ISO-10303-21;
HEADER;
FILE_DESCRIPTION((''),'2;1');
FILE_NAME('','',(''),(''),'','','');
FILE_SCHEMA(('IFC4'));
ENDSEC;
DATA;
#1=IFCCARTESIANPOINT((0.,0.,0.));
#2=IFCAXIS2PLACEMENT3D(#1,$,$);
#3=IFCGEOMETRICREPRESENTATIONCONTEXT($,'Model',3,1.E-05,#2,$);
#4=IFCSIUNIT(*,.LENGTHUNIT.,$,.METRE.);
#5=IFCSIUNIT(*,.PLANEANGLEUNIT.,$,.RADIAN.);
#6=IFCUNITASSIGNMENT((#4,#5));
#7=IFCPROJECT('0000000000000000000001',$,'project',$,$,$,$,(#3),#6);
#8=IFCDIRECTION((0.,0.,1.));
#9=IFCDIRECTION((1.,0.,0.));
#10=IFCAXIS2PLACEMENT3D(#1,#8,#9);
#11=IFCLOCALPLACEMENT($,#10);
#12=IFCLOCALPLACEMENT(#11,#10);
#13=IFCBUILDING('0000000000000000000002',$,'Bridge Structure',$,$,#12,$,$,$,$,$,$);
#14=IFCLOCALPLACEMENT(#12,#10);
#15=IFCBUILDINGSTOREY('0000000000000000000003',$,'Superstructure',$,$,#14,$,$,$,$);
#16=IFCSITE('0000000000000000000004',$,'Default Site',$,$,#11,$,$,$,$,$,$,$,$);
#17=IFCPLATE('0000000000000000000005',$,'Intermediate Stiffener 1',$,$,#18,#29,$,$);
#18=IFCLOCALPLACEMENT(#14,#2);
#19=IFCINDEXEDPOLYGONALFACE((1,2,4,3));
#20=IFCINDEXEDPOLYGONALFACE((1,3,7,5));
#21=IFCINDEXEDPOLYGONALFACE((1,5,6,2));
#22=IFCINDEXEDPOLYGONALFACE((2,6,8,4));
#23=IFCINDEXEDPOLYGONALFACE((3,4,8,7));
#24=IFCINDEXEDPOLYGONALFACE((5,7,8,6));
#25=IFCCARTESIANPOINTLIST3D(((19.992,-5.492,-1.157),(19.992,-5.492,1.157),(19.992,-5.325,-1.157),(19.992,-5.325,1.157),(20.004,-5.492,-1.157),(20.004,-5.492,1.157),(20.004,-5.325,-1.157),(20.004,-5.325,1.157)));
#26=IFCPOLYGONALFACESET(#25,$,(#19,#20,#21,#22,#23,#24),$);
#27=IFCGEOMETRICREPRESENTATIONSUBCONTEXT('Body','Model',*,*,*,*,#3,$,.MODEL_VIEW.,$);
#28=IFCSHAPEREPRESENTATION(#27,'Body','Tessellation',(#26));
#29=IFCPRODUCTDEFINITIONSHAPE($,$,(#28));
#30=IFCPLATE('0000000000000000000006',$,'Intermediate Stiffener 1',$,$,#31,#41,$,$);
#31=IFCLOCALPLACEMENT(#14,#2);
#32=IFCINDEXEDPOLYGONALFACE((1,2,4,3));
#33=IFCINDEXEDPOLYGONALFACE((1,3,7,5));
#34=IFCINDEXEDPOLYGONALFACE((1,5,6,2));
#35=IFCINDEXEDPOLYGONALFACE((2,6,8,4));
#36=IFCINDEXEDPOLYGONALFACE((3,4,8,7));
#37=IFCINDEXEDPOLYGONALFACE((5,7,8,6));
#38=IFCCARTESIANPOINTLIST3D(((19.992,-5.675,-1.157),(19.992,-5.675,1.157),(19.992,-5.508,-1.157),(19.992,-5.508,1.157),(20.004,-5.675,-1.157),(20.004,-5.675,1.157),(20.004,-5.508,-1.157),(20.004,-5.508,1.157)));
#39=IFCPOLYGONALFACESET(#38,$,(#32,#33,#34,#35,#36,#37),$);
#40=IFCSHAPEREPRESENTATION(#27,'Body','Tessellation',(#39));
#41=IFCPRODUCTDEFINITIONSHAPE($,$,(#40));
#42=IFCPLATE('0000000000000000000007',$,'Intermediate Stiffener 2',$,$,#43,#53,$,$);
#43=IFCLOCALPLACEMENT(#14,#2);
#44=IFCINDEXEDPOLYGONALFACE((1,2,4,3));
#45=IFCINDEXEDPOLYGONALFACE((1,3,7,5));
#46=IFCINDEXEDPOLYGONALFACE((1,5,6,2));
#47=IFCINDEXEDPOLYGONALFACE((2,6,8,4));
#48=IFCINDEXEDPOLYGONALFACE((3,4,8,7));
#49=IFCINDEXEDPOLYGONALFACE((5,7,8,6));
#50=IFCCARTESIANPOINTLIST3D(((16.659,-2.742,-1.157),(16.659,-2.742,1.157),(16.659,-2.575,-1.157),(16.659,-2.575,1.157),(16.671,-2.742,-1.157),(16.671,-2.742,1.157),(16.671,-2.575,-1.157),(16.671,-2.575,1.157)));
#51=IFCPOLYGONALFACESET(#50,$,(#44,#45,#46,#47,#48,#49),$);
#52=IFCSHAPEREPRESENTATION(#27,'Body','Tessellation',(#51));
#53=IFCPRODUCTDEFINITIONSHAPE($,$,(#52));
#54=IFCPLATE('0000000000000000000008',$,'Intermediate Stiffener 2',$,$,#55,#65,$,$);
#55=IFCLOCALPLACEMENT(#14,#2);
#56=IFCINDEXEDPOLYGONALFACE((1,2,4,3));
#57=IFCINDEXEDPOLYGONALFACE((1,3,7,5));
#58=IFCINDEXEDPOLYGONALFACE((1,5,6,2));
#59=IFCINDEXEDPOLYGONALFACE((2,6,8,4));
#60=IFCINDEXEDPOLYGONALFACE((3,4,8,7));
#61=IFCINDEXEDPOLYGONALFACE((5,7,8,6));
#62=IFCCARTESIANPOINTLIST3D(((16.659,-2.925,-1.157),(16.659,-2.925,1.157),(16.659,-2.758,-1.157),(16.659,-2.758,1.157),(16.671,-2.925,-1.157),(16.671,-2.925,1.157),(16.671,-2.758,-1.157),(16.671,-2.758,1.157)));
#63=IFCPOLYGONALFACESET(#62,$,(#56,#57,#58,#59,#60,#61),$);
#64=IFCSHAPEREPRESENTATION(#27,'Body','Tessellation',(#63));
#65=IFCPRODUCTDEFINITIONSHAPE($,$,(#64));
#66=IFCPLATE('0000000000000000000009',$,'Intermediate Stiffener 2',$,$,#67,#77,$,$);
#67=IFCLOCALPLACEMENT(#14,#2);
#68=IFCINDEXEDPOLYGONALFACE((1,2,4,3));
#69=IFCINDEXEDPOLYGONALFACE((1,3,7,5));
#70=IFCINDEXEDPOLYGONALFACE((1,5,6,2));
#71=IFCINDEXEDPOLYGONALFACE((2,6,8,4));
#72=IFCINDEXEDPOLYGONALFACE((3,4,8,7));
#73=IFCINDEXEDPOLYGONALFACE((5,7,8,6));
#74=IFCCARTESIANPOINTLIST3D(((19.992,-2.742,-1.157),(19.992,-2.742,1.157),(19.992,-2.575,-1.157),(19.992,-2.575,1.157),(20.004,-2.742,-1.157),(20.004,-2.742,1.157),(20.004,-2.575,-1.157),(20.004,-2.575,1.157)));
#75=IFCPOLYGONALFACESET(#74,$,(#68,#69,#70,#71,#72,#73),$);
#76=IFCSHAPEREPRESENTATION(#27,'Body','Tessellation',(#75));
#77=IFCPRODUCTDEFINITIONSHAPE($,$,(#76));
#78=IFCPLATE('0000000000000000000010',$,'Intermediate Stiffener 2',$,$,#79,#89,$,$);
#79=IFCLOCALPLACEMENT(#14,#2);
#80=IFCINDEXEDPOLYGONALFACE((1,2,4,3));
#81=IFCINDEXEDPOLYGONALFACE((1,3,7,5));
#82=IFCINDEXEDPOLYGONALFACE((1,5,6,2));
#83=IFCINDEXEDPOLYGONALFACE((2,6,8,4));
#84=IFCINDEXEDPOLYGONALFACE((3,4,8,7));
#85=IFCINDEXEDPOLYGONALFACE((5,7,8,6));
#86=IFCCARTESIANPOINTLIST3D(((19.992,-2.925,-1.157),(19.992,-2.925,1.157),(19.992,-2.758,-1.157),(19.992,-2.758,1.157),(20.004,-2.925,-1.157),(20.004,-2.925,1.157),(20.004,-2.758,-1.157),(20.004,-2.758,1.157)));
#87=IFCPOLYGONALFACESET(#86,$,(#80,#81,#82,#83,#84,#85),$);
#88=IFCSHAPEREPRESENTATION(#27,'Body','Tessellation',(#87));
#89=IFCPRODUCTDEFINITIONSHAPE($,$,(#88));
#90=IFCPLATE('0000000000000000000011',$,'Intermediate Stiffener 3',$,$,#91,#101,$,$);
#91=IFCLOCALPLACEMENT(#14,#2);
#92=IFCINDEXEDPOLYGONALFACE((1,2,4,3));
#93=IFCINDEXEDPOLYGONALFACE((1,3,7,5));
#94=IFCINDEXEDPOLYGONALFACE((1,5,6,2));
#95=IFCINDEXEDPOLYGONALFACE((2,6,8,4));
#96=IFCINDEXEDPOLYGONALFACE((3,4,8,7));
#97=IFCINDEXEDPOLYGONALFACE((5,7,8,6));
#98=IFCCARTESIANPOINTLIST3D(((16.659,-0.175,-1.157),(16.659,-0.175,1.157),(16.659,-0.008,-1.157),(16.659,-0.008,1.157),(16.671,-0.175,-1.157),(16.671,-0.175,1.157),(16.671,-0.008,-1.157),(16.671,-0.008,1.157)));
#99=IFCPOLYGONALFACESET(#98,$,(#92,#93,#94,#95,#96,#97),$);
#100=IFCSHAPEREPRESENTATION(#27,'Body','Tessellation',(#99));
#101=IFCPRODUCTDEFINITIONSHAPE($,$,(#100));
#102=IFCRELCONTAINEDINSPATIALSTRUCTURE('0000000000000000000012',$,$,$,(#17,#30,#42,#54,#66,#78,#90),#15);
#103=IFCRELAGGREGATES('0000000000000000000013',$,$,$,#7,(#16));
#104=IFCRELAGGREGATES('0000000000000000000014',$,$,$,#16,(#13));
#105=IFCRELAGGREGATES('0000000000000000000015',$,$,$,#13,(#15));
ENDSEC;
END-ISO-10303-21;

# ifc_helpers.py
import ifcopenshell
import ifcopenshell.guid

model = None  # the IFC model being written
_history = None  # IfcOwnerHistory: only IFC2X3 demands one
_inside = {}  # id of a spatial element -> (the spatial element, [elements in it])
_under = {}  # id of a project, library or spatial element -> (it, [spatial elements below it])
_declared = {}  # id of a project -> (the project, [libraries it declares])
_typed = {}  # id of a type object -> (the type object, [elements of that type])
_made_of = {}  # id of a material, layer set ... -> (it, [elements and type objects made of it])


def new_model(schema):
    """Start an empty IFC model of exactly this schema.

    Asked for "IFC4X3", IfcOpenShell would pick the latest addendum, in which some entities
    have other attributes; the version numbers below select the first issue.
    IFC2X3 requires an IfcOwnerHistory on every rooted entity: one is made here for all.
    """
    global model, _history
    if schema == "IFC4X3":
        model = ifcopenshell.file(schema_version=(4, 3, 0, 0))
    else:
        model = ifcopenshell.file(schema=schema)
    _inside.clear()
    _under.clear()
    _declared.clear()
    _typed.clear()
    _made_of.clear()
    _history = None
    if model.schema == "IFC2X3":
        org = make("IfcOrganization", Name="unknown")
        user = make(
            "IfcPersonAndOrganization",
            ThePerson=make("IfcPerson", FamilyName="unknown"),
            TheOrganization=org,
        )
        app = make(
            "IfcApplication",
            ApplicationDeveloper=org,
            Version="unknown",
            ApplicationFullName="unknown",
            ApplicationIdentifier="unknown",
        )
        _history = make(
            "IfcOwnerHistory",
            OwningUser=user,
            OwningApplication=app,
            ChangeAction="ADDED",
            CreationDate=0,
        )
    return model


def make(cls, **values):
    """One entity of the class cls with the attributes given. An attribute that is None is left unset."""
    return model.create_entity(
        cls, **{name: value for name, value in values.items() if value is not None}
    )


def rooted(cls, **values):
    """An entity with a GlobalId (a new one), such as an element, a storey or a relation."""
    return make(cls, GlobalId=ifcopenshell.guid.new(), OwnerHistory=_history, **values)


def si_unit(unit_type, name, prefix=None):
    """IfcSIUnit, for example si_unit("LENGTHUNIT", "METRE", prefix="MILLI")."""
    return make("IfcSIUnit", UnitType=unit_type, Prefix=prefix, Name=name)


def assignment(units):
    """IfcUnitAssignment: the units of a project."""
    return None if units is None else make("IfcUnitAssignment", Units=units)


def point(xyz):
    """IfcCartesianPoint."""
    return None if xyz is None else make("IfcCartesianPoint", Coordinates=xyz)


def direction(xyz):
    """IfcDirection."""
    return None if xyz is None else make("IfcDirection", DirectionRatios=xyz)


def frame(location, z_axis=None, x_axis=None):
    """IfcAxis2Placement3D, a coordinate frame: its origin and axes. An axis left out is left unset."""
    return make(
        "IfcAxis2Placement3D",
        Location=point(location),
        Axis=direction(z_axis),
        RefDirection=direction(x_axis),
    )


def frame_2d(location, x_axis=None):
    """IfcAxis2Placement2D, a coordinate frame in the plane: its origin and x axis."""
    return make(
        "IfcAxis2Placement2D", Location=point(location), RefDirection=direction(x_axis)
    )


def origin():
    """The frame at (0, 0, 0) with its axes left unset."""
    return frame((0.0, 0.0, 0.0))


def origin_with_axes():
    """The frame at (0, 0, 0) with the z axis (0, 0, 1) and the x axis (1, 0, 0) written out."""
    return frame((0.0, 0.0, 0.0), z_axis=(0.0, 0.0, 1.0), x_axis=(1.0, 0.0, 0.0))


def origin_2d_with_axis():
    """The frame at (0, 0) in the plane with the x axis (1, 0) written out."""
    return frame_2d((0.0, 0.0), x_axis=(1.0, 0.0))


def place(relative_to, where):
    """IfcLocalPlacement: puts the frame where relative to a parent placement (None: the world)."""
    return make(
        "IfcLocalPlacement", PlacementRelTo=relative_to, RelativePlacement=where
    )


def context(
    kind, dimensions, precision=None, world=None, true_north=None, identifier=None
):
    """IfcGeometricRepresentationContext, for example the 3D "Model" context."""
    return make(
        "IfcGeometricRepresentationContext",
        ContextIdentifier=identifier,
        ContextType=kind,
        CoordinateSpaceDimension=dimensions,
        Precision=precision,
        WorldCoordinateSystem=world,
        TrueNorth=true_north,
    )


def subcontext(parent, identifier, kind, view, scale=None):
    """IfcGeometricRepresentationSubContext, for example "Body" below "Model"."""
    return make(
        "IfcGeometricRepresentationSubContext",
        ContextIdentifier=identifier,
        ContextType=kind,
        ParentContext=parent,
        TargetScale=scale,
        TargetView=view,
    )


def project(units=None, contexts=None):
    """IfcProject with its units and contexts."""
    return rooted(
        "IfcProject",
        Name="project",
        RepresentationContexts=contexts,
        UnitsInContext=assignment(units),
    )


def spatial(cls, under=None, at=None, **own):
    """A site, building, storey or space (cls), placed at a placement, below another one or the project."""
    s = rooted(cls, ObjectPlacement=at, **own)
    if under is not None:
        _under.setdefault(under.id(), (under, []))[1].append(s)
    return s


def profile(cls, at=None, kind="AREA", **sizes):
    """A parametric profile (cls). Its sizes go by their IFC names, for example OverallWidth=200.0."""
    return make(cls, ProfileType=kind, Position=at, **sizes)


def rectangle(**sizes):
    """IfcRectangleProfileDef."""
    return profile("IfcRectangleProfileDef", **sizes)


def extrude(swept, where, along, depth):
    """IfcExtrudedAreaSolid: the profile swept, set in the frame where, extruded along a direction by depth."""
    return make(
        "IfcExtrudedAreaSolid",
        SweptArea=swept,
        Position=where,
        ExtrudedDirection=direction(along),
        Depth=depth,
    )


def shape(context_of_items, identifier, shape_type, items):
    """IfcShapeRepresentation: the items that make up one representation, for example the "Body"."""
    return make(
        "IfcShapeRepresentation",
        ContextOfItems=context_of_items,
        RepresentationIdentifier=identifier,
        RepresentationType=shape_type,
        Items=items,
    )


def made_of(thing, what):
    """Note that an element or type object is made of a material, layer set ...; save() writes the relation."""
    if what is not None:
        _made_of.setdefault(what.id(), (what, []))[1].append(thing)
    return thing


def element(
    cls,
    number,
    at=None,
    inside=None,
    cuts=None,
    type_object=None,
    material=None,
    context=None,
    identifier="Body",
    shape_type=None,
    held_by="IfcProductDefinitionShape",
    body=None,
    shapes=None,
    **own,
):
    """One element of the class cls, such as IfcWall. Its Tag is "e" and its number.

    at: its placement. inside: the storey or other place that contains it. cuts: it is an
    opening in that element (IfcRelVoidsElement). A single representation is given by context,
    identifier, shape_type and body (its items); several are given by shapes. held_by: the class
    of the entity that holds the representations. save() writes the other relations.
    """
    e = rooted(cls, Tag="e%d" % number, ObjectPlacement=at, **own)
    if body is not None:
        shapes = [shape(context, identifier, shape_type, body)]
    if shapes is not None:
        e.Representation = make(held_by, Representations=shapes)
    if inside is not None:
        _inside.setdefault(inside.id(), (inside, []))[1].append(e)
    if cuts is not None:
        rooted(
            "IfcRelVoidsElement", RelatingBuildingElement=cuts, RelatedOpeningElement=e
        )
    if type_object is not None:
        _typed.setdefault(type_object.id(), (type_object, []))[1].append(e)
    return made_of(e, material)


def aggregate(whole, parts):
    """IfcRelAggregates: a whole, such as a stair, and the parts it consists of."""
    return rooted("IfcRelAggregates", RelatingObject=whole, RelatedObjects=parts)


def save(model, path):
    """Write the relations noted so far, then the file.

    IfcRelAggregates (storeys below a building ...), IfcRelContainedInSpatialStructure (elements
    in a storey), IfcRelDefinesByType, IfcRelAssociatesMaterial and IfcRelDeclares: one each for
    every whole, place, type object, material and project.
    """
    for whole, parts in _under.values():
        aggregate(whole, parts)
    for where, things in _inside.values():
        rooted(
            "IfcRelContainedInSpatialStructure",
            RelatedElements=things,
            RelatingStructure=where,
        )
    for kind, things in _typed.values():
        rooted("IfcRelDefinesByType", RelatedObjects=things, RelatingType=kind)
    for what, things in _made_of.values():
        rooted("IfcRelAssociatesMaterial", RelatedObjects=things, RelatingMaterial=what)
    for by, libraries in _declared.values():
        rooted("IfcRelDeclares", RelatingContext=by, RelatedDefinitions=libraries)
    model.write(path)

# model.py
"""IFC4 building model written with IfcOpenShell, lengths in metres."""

from ifc_helpers import new_model, si_unit, frame, origin, origin_with_axes, origin_2d_with_axis, place, context, subcontext, project, spatial, rectangle, extrude, element, save


model = new_model("IFC4")

# Units and contexts
model_context = context("Model", 3, precision=1e-05, world=origin())
body_context = subcontext(model_context, "Body", "Model", "MODEL_VIEW")
ifc_project = project(units=[si_unit("LENGTHUNIT", "METRE"), si_unit("PLANEANGLEUNIT", "RADIAN")], contexts=[model_context])

# Site, building, storey
site_placement = place(None, origin_with_axes())
site = spatial("IfcSite", under=ifc_project, at=site_placement, Name="Default Site")
building_placement = place(site_placement, origin_with_axes())
building = spatial("IfcBuilding", under=site, at=building_placement, Name="Bridge Structure")
storey_placement = place(building_placement, origin_with_axes())
storey = spatial("IfcBuildingStorey", under=building, at=storey_placement, Name="Superstructure")

# Plates
for number, where, z_axis, x_axis, name in (
    (1, (19.998, -5.4085, -1.157), (0.0, 0.0, 1.0), (1.0, 0.0, 0.0), "Intermediate Stiffener 1"),
    (2, (19.998, -5.5915, -1.157), (0.0, 0.0, 1.0), (1.0, 0.0, 0.0), "Intermediate Stiffener 1"),
    (3, (16.665, -2.6585, -1.157), (0.0, 0.0, 1.0), (1.0, 0.0, 0.0), "Intermediate Stiffener 2"),
    (4, (16.665, -2.8415, -1.157), (0.0, 0.0, 1.0), (1.0, 0.0, 0.0), "Intermediate Stiffener 2"),
    (5, (19.998, -2.6585, -1.157), (0.0, 0.0, 1.0), (1.0, 0.0, 0.0), "Intermediate Stiffener 2"),
    (6, (19.998, -2.8415, -1.157), (0.0, 0.0, 1.0), (1.0, 0.0, 0.0), "Intermediate Stiffener 2"),
    (7, (16.665, -0.0915, -1.157), (0.0, 0.0, 1.0), (1.0, 0.0, 0.0), "Intermediate Stiffener 3"),
):
    element("IfcPlate", number, at=place(storey_placement, frame(where, z_axis=z_axis, x_axis=x_axis)), inside=storey, Name=name, context=body_context, shape_type="SweptSolid", body=[
        extrude(rectangle(XDim=0.012, YDim=0.167, at=origin_2d_with_axis()), origin_with_axes(), (0.0, 0.0, 1.0), 2.314),
    ])

save(model, "model.ifc")
